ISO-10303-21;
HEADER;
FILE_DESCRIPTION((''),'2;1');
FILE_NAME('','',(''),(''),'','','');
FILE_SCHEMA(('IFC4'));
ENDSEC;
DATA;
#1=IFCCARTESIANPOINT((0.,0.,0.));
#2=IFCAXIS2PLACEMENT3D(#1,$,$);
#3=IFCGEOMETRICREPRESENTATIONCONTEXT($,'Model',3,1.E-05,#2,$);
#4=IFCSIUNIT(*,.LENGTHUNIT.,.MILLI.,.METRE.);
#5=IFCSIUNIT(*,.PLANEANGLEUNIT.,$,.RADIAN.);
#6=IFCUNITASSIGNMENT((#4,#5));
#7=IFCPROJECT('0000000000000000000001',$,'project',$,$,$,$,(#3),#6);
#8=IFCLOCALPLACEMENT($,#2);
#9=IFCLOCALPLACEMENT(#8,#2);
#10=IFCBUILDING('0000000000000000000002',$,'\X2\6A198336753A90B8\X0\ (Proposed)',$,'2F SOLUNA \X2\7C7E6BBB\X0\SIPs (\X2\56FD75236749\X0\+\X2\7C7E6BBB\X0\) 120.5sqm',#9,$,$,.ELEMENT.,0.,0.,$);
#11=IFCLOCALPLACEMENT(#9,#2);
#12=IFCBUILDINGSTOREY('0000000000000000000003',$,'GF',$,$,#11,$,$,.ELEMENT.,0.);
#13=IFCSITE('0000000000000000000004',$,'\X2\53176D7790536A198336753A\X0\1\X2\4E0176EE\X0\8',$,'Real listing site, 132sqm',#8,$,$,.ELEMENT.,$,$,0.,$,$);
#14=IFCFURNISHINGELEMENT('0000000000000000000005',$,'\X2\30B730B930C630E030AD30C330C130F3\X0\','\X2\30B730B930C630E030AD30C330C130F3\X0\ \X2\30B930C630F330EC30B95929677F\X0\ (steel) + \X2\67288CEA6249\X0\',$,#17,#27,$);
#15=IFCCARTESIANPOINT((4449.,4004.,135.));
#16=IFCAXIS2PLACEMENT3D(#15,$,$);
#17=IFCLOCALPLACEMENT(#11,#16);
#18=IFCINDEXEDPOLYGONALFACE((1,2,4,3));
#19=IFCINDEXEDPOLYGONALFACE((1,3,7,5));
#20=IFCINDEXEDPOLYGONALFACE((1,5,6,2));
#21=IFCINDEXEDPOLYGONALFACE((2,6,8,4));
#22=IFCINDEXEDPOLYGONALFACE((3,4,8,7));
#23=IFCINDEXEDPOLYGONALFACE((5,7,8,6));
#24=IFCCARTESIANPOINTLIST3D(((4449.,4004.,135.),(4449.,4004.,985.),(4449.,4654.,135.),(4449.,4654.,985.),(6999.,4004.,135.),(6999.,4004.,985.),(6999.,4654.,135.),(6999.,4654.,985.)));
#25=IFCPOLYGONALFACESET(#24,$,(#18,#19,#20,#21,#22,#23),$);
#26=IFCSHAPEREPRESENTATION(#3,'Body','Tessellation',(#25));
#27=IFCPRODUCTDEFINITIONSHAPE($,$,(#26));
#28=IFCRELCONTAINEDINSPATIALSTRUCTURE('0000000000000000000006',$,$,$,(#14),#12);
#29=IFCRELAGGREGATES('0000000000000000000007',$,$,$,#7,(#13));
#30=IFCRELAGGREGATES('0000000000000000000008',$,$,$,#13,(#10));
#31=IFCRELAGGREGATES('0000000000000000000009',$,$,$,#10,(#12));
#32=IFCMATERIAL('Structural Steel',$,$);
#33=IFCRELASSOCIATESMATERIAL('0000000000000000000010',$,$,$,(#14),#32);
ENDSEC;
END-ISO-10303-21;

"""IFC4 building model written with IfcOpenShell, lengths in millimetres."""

from ifc_helpers import new_model, si_unit, frame, frame_2d, origin, place, context, project, spatial, rectangle, extrude, material, element, save


model = new_model("IFC4")

# Units and contexts
model_context = context("Model", 3, precision=1e-05, world=origin())
ifc_project = project(units=[si_unit("LENGTHUNIT", "METRE", prefix="MILLI"), si_unit("PLANEANGLEUNIT", "RADIAN")], contexts=[model_context])

# Site, building, storey
site_placement = place(None, origin())
site = spatial("IfcSite", under=ifc_project, at=site_placement, Name="北海道標茶町1丁目8", ObjectType="Real listing site, 132sqm", CompositionType="ELEMENT", RefElevation=0.0)
building_placement = place(site_placement, origin())
building = spatial("IfcBuilding", under=site, at=building_placement, Name="標茶町邸 (Proposed)", ObjectType="2F SOLUNA 籾殻SIPs (国産杉+籾殻) 120.5sqm", CompositionType="ELEMENT", ElevationOfRefHeight=0.0, ElevationOfTerrain=0.0)
storey_placement = place(building_placement, origin())
storey = spatial("IfcBuildingStorey", under=building, at=storey_placement, Name="GF", CompositionType="ELEMENT", Elevation=0.0)

# Furnishing element
ifc_material_1 = material(Name="Structural Steel")
furnishing_placement = place(storey_placement, frame((4449.0, 4004.0, 135.0)))
element("IfcFurnishingElement", 1, at=furnishing_placement, inside=storey, material=ifc_material_1, Name="システムキッチン", Description="システムキッチン ステンレス天板 (steel) + 木質扉", context=model_context, shape_type="SweptSolid", body=[
    extrude(rectangle(XDim=2550.0, YDim=650.0, at=frame_2d((1275.0, 325.0))), frame((4449.0, 4004.0, 135.0)), (0.0, 0.0, 1.0), 850.0),
])

save(model, "model.ifc")
